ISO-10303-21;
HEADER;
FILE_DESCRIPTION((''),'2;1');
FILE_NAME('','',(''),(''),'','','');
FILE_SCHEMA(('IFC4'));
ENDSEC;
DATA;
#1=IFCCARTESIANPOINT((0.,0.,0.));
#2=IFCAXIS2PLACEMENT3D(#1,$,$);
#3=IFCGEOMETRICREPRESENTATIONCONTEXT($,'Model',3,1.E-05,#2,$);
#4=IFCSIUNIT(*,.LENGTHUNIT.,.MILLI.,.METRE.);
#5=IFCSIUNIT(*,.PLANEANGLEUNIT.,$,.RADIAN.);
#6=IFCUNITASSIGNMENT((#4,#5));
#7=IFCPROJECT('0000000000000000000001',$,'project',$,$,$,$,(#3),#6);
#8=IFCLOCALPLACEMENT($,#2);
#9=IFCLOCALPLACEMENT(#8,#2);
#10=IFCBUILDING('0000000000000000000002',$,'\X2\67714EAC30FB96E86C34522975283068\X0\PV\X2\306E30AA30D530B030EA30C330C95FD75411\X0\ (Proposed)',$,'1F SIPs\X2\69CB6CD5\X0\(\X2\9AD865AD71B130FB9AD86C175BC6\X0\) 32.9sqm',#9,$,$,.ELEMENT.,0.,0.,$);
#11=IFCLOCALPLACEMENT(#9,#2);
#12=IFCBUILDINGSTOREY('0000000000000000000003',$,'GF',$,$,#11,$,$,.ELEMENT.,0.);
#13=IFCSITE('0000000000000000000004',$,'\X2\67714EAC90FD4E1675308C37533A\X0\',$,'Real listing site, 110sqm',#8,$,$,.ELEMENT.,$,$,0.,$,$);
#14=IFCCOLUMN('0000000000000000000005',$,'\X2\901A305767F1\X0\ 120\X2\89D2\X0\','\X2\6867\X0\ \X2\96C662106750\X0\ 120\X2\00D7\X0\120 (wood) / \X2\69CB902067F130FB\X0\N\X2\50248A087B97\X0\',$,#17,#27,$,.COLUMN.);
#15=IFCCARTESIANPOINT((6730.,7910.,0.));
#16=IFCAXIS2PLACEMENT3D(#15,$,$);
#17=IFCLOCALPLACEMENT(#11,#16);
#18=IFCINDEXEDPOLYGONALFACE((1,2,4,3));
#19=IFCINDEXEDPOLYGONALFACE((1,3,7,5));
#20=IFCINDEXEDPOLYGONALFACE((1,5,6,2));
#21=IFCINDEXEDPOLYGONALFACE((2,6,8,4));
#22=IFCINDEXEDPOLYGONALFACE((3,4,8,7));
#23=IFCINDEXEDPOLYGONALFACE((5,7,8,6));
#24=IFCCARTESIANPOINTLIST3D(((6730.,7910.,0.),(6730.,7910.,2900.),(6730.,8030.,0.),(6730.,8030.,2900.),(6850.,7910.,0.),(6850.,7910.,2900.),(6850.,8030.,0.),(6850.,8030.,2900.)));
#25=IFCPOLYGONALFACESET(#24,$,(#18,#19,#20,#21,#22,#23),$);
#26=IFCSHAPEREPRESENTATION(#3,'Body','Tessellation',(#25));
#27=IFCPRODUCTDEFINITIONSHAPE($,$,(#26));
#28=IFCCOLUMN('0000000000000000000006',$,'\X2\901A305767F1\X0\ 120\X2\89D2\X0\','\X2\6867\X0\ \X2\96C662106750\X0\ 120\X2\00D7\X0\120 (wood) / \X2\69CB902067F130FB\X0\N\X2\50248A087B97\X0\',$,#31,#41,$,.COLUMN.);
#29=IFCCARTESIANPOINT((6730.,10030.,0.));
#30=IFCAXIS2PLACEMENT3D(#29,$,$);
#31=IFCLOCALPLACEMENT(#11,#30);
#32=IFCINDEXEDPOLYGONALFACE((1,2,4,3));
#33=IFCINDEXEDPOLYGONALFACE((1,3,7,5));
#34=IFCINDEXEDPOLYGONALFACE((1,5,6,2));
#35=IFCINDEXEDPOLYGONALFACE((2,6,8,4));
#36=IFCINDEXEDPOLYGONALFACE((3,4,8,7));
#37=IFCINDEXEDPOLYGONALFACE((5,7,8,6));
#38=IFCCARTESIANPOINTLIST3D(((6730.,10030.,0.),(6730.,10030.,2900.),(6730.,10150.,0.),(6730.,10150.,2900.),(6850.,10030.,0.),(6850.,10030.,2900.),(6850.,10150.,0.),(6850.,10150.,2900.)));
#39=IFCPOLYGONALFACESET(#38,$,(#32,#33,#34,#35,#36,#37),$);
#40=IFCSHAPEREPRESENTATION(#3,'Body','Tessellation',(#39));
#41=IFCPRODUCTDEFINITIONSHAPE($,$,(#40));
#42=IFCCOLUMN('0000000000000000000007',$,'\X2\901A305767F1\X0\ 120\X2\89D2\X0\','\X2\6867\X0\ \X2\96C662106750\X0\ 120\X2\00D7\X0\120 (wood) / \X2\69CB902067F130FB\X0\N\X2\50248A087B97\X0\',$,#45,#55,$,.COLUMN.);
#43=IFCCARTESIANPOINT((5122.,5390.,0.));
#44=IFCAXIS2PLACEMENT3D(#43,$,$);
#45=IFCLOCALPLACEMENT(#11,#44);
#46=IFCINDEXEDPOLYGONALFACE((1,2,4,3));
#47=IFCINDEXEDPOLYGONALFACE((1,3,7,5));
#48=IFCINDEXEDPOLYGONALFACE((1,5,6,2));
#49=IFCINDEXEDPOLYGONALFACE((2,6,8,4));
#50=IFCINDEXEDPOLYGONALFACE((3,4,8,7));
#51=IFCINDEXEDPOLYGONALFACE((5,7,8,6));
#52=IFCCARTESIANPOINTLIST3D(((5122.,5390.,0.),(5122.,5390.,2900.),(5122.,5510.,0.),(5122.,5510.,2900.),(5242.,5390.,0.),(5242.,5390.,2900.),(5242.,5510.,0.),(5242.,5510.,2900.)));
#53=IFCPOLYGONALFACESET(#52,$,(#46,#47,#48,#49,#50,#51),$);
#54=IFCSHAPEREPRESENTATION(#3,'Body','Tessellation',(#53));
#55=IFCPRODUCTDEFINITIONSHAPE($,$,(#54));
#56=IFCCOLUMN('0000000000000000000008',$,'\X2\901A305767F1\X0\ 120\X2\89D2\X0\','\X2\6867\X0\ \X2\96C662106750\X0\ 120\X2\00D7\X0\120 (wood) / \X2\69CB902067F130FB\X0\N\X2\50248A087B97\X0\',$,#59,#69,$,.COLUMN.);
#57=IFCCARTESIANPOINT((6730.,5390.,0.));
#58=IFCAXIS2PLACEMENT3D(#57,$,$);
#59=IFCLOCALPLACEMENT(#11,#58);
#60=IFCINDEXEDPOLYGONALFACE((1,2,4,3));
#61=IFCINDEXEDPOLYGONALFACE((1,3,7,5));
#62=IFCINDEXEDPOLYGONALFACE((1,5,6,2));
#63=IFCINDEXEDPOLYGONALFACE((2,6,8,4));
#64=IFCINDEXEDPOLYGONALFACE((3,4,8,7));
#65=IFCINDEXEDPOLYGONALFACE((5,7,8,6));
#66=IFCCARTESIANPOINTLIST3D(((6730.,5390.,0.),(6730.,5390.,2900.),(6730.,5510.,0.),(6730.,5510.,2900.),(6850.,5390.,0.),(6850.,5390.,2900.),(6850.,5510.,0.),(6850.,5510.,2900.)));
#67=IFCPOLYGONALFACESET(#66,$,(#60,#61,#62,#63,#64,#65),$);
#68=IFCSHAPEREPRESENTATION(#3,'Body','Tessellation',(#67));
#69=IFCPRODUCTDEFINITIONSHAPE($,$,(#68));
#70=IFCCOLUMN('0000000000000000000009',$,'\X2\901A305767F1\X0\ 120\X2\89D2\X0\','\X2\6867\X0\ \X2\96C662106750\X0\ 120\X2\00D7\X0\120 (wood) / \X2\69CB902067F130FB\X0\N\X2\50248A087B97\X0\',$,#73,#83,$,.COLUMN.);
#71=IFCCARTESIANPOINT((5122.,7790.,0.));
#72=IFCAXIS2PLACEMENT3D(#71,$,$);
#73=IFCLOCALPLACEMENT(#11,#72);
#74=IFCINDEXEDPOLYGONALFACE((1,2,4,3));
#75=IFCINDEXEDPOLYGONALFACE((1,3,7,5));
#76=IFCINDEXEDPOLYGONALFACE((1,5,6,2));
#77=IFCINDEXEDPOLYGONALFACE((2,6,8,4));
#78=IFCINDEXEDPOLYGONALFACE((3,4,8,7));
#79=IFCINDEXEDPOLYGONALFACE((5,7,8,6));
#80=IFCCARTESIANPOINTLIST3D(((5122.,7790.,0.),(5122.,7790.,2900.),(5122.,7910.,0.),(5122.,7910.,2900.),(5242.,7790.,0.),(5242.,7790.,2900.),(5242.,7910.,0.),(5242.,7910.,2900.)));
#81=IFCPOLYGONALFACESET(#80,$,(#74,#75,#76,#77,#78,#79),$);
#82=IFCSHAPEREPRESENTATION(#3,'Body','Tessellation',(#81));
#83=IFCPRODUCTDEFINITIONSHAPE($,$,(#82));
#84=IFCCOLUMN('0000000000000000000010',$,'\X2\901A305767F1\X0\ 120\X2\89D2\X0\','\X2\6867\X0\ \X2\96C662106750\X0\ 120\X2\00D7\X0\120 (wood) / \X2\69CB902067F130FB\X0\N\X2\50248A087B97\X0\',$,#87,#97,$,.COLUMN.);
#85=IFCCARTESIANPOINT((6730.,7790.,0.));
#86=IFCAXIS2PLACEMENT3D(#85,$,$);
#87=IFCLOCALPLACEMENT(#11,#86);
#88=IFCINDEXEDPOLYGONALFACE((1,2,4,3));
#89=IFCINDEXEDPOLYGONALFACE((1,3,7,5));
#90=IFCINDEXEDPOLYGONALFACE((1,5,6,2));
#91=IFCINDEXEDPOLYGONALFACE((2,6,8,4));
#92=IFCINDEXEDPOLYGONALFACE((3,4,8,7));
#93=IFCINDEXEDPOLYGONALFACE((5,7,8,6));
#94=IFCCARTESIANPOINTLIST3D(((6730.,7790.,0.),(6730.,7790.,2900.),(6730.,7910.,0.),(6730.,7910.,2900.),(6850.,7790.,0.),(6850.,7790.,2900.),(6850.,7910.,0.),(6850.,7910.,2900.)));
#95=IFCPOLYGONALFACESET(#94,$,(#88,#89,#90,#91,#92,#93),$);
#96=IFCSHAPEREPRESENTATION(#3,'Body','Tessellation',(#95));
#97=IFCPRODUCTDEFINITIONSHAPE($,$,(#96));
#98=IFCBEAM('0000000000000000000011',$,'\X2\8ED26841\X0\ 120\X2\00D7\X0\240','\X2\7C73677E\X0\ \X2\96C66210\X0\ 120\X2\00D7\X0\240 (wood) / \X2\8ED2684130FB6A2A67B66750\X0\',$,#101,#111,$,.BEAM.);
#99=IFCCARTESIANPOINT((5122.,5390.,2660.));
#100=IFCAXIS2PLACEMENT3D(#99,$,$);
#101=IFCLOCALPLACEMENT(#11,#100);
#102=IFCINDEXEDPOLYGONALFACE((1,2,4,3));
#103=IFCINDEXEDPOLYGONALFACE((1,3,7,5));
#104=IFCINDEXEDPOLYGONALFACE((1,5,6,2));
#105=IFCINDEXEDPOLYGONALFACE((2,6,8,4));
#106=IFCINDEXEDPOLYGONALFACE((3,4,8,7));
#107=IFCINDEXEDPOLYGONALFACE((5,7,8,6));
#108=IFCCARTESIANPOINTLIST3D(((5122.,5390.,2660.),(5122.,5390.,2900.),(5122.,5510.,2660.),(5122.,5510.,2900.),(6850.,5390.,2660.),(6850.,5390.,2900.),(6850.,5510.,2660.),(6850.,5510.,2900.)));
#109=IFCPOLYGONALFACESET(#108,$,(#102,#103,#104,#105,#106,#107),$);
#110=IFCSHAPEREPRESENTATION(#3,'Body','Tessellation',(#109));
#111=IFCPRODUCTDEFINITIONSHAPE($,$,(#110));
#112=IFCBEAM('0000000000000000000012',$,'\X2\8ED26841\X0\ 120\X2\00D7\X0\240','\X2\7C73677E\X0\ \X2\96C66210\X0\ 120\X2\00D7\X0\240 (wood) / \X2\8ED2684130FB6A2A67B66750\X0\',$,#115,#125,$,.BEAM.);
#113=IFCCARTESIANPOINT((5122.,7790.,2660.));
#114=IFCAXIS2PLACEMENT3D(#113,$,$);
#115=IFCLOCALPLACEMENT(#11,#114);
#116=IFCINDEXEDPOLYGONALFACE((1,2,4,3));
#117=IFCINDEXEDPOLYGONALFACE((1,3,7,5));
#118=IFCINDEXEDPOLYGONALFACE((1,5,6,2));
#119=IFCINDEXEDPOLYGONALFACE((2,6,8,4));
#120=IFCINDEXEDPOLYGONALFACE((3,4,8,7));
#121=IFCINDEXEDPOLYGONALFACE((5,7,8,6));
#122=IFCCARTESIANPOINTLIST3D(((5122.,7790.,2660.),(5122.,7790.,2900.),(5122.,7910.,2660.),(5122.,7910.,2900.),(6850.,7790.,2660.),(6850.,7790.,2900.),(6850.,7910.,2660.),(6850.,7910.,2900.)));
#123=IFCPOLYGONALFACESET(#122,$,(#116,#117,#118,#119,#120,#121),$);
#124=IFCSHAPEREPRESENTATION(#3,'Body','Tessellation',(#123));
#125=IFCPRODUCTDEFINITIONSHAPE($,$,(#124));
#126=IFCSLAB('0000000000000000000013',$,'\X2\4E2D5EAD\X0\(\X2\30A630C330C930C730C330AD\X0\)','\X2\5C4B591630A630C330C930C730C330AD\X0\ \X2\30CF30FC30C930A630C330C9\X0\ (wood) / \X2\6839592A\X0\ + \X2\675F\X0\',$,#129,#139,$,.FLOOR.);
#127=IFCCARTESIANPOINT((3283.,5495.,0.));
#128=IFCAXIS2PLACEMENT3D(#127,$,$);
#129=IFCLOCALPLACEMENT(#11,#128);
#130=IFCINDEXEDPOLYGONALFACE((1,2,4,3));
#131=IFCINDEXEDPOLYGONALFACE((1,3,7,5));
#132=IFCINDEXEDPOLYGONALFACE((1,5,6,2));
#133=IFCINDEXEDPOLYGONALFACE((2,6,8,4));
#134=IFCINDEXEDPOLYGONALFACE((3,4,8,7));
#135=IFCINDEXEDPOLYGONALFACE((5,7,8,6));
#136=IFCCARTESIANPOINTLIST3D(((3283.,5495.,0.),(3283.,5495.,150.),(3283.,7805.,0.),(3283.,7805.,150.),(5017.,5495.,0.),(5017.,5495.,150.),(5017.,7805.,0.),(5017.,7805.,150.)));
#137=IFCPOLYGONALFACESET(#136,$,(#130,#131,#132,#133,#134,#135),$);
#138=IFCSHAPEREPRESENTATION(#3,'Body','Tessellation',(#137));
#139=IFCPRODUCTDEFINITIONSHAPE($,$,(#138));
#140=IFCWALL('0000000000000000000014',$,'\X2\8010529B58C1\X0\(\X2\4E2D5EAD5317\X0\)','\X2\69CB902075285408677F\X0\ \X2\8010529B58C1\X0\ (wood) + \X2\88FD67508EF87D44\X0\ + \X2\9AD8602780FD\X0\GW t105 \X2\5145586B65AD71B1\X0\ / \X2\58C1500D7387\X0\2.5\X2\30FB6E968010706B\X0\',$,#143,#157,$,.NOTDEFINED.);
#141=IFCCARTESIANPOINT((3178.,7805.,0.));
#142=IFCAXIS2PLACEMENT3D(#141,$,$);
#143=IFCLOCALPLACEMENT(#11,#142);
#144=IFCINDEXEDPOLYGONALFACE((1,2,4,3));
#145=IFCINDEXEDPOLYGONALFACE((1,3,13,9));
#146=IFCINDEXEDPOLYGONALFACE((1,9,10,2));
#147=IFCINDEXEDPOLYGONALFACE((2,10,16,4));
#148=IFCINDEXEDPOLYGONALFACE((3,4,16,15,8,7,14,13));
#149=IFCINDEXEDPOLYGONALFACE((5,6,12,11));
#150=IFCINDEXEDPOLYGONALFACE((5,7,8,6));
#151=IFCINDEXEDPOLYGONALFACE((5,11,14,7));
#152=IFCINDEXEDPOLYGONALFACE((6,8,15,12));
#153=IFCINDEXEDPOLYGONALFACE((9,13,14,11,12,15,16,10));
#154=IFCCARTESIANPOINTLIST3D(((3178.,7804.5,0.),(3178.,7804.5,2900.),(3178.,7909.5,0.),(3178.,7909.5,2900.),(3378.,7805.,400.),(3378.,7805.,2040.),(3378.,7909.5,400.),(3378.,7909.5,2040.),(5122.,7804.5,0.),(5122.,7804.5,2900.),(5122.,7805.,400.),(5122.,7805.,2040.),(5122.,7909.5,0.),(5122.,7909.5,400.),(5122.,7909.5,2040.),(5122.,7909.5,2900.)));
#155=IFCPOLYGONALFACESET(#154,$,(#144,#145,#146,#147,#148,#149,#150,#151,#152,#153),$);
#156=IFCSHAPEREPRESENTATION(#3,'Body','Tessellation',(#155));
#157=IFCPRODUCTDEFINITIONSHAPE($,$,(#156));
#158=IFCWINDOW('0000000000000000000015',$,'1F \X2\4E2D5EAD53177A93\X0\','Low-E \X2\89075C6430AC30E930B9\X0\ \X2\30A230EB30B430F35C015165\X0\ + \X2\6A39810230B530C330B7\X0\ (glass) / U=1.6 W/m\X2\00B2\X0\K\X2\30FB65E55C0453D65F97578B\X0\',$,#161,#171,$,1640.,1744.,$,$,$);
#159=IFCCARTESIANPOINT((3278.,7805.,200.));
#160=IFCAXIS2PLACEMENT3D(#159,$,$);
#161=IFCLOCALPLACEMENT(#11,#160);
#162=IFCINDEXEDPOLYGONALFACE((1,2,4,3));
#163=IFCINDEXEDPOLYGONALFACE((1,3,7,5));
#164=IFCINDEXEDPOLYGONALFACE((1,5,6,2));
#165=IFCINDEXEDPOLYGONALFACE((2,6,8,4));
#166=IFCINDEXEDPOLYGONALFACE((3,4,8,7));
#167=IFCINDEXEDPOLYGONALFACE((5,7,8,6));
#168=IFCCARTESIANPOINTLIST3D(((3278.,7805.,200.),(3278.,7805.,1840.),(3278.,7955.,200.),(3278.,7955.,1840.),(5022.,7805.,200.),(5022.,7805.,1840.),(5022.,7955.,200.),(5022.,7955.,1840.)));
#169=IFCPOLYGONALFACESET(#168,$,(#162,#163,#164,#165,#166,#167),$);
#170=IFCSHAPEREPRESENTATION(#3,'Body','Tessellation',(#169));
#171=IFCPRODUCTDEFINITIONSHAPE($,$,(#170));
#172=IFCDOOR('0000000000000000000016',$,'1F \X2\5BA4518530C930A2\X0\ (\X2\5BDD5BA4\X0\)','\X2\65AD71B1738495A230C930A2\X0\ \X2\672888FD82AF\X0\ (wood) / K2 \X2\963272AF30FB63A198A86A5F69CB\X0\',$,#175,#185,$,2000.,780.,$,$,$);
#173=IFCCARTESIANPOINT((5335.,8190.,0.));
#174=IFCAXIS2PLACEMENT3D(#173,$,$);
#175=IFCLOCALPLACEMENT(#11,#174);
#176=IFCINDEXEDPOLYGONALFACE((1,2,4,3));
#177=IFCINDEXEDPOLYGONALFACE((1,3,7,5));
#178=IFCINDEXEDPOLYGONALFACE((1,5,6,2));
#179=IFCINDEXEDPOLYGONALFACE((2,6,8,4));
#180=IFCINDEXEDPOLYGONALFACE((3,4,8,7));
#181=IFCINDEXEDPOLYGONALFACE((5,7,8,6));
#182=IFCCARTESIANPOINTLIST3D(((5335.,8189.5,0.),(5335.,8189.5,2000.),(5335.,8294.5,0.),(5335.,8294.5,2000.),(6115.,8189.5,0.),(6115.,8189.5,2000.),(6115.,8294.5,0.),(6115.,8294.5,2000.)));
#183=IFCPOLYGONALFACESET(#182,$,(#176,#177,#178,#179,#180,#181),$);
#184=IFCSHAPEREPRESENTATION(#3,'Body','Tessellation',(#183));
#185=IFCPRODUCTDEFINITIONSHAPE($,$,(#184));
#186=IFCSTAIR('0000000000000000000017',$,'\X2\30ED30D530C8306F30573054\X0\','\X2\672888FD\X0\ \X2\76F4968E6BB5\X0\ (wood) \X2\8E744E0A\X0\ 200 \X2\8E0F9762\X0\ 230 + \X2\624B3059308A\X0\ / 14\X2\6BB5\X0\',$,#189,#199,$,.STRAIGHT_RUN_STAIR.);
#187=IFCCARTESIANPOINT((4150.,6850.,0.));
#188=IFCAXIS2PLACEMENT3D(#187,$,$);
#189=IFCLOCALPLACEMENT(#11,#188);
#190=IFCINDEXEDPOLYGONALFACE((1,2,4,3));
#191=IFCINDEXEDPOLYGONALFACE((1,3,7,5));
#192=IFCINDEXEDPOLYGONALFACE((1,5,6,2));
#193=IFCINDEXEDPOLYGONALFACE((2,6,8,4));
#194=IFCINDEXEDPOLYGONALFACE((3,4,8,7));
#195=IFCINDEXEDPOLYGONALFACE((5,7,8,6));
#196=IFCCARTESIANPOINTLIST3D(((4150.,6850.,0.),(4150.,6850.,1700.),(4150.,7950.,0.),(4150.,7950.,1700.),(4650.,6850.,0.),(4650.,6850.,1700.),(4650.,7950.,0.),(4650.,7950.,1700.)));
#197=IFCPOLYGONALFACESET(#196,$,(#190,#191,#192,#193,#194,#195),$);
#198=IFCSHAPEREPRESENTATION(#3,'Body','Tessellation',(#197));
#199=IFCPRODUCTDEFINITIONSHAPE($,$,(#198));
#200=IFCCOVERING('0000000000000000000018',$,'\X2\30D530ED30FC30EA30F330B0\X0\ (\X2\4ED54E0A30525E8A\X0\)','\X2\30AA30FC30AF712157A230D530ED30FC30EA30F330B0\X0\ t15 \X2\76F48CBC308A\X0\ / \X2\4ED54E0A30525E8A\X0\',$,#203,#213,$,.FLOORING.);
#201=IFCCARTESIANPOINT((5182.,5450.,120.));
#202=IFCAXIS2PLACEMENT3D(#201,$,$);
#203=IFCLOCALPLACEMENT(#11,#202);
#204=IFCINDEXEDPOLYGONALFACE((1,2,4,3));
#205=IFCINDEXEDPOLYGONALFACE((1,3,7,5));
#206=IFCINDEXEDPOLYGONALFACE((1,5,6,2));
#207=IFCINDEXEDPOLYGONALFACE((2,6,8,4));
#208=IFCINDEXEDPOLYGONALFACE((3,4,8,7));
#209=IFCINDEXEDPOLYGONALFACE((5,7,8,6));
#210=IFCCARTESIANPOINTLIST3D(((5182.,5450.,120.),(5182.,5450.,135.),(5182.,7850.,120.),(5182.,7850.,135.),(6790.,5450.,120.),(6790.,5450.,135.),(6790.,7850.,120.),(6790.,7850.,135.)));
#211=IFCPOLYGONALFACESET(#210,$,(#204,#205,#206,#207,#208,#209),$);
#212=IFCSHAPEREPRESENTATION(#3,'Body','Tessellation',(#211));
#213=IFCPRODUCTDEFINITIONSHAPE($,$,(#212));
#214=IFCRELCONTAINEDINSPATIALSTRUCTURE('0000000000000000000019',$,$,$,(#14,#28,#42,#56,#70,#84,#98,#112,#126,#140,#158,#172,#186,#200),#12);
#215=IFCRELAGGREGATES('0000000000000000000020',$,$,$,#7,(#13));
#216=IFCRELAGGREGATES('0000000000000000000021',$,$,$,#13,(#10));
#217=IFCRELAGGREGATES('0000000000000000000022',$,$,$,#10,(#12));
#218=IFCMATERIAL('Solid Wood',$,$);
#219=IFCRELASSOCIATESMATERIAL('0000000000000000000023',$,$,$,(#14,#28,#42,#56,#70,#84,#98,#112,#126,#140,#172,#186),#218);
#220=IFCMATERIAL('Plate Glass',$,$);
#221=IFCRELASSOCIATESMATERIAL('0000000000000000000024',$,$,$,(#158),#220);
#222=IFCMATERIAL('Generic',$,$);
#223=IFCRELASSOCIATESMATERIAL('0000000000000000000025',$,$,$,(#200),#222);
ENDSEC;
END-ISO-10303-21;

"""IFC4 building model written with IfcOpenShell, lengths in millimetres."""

from ifc_helpers import new_model, si_unit, frame, frame_2d, origin, place, context, project, spatial, rectangle, extrude, material, element, fill, save


model = new_model("IFC4")

# Units and contexts
model_context = context("Model", 3, precision=1e-05, world=origin())
ifc_project = project(units=[si_unit("LENGTHUNIT", "METRE", prefix="MILLI"), si_unit("PLANEANGLEUNIT", "RADIAN")], contexts=[model_context])

# Site, building, storey
site_placement = place(None, origin())
site = spatial("IfcSite", under=ifc_project, at=site_placement, Name="東京都世田谷区", ObjectType="Real listing site, 110sqm", CompositionType="ELEMENT", RefElevation=0.0)
building_placement = place(site_placement, origin())
building = spatial("IfcBuilding", under=site, at=building_placement, Name="東京・雨水利用とPVのオフグリッド志向 (Proposed)", ObjectType="1F SIPs構法(高断熱・高気密) 32.9sqm", CompositionType="ELEMENT", ElevationOfRefHeight=0.0, ElevationOfTerrain=0.0)
storey_placement = place(building_placement, origin())
storey = spatial("IfcBuildingStorey", under=building, at=storey_placement, Name="GF", CompositionType="ELEMENT", Elevation=0.0)

# Columns
ifc_material_1 = material(Name="Solid Wood")
column_1_placement = place(storey_placement, frame((6730.0, 7910.0, 0.0)))
element("IfcColumn", 1, at=column_1_placement, inside=storey, material=ifc_material_1, Name="通し柱 120角", Description="桧 集成材 120×120 (wood) / 構造柱・N値計算", PredefinedType="COLUMN", context=model_context, shape_type="SweptSolid", body=[
    extrude(rectangle(XDim=120.0, YDim=120.0, at=frame_2d((60.0, 60.0))), frame((6730.0, 7910.0, 0.0)), (0.0, 0.0, 1.0), 2900.0),
])
column_2_placement = place(storey_placement, frame((6730.0, 10030.0, 0.0)))
element("IfcColumn", 2, at=column_2_placement, inside=storey, material=ifc_material_1, Name="通し柱 120角", Description="桧 集成材 120×120 (wood) / 構造柱・N値計算", PredefinedType="COLUMN", context=model_context, shape_type="SweptSolid", body=[
    extrude(rectangle(XDim=120.0, YDim=120.0, at=frame_2d((60.0, 60.0))), frame((6730.0, 10030.0, 0.0)), (0.0, 0.0, 1.0), 2900.0),
])
column_3_placement = place(storey_placement, frame((5122.0, 5390.0, 0.0)))
element("IfcColumn", 3, at=column_3_placement, inside=storey, material=ifc_material_1, Name="通し柱 120角", Description="桧 集成材 120×120 (wood) / 構造柱・N値計算", PredefinedType="COLUMN", context=model_context, shape_type="SweptSolid", body=[
    extrude(rectangle(XDim=120.0, YDim=120.0, at=frame_2d((60.0, 60.0))), frame((5122.0, 5390.0, 0.0)), (0.0, 0.0, 1.0), 2900.0),
])
column_4_placement = place(storey_placement, frame((6730.0, 5390.0, 0.0)))
element("IfcColumn", 4, at=column_4_placement, inside=storey, material=ifc_material_1, Name="通し柱 120角", Description="桧 集成材 120×120 (wood) / 構造柱・N値計算", PredefinedType="COLUMN", context=model_context, shape_type="SweptSolid", body=[
    extrude(rectangle(XDim=120.0, YDim=120.0, at=frame_2d((60.0, 60.0))), frame((6730.0, 5390.0, 0.0)), (0.0, 0.0, 1.0), 2900.0),
])
column_5_placement = place(storey_placement, frame((5122.0, 7790.0, 0.0)))
element("IfcColumn", 5, at=column_5_placement, inside=storey, material=ifc_material_1, Name="通し柱 120角", Description="桧 集成材 120×120 (wood) / 構造柱・N値計算", PredefinedType="COLUMN", context=model_context, shape_type="SweptSolid", body=[
    extrude(rectangle(XDim=120.0, YDim=120.0, at=frame_2d((60.0, 60.0))), frame((5122.0, 7790.0, 0.0)), (0.0, 0.0, 1.0), 2900.0),
])
column_6_placement = place(storey_placement, frame((6730.0, 7790.0, 0.0)))
element("IfcColumn", 6, at=column_6_placement, inside=storey, material=ifc_material_1, Name="通し柱 120角", Description="桧 集成材 120×120 (wood) / 構造柱・N値計算", PredefinedType="COLUMN", context=model_context, shape_type="SweptSolid", body=[
    extrude(rectangle(XDim=120.0, YDim=120.0, at=frame_2d((60.0, 60.0))), frame((6730.0, 7790.0, 0.0)), (0.0, 0.0, 1.0), 2900.0),
])

# Beams
beam_1_placement = place(storey_placement, frame((5122.0, 5390.0, 2660.0)))
element("IfcBeam", 7, at=beam_1_placement, inside=storey, material=ifc_material_1, Name="軒桁 120×240", Description="米松 集成 120×240 (wood) / 軒桁・横架材", PredefinedType="BEAM", context=model_context, shape_type="SweptSolid", body=[
    extrude(rectangle(XDim=1728.0, YDim=120.0, at=frame_2d((864.0, 60.0))), frame((5122.0, 5390.0, 2660.0)), (0.0, 0.0, 1.0), 240.0),
])
beam_2_placement = place(storey_placement, frame((5122.0, 7790.0, 2660.0)))
element("IfcBeam", 8, at=beam_2_placement, inside=storey, material=ifc_material_1, Name="軒桁 120×240", Description="米松 集成 120×240 (wood) / 軒桁・横架材", PredefinedType="BEAM", context=model_context, shape_type="SweptSolid", body=[
    extrude(rectangle(XDim=1728.0, YDim=120.0, at=frame_2d((864.0, 60.0))), frame((5122.0, 7790.0, 2660.0)), (0.0, 0.0, 1.0), 240.0),
])

# Slab
slab_placement = place(storey_placement, frame((3283.0, 5495.0, 0.0)))
element("IfcSlab", 9, at=slab_placement, inside=storey, material=ifc_material_1, Name="中庭(ウッドデッキ)", Description="屋外ウッドデッキ ハードウッド (wood) / 根太 + 束", PredefinedType="FLOOR", context=model_context, shape_type="SweptSolid", body=[
    extrude(rectangle(XDim=1734.0, YDim=2310.0, at=frame_2d((867.0, 1155.0))), frame((3283.0, 5495.0, 0.0)), (0.0, 0.0, 1.0), 150.0),
])

# Wall, opening, window
wall_1_placement = place(storey_placement, frame((3178.0, 7805.0, 0.0)))
wall_1 = element("IfcWall", 10, at=wall_1_placement, inside=storey, material=ifc_material_1, Name="耐力壁(中庭北)", Description="構造用合板 耐力壁 (wood) + 製材軸組 + 高性能GW t105 充填断熱 / 壁倍率2.5・準耐火", PredefinedType="NOTDEFINED", context=model_context, shape_type="SweptSolid", body=[
    extrude(rectangle(XDim=1944.0, YDim=105.0, at=frame_2d((972.0, 52.0))), frame((3178.0, 7805.0, 0.0)), (0.0, 0.0, 1.0), 2900.0),
])
opening_placement = place(storey_placement, frame((3278.0, 7805.0, 200.0)))
opening = element("IfcOpeningElement", 11, at=opening_placement, cuts=wall_1, PredefinedType="NOTDEFINED", context=model_context, shape_type="SweptSolid", body=[
    extrude(rectangle(XDim=1744.0, YDim=150.0, at=frame_2d((872.0, 75.0))), frame((3278.0, 7805.0, 200.0)), (0.0, 0.0, 1.0), 1640.0),
])
ifc_material_2 = material(Name="Plate Glass")
window_placement = place(storey_placement, frame((3278.0, 7805.0, 200.0)))
window = element("IfcWindow", 12, at=window_placement, inside=storey, material=ifc_material_2, Name="1F 中庭北窓", Description="Low-E 複層ガラス アルゴン封入 + 樹脂サッシ (glass) / U=1.6 W/m²K・日射取得型", OverallHeight=1640.0, OverallWidth=1744.0, context=model_context, shape_type="SweptSolid", body=[
    extrude(rectangle(XDim=1744.0, YDim=150.0, at=frame_2d((872.0, 75.0))), frame((3278.0, 7805.0, 200.0)), (0.0, 0.0, 1.0), 1640.0),
])
fill(opening, window)

# Door
door_placement = place(storey_placement, frame((5335.0, 8190.0, 0.0)))
element("IfcDoor", 13, at=door_placement, inside=storey, material=ifc_material_1, Name="1F 室内ドア (寝室)", Description="断熱玄関ドア 木製芯 (wood) / K2 防犯・採風機構", OverallHeight=2000.0, OverallWidth=780.0, context=model_context, shape_type="SweptSolid", body=[
    extrude(rectangle(XDim=780.0, YDim=105.0, at=frame_2d((390.0, 52.0))), frame((5335.0, 8190.0, 0.0)), (0.0, 0.0, 1.0), 2000.0),
])

# Stair
stair_placement = place(storey_placement, frame((4150.0, 6850.0, 0.0)))
element("IfcStair", 14, at=stair_placement, inside=storey, material=ifc_material_1, Name="ロフトはしご", Description="木製 直階段 (wood) 蹴上 200 踏面 230 + 手すり / 14段", PredefinedType="STRAIGHT_RUN_STAIR", context=model_context, shape_type="SweptSolid", body=[
    extrude(rectangle(XDim=500.0, YDim=1100.0, at=frame_2d((250.0, 550.0))), frame((4150.0, 6850.0, 0.0)), (0.0, 0.0, 1.0), 1700.0),
])

# Covering
ifc_material_3 = material(Name="Generic")
covering_placement = place(storey_placement, frame((5182.0, 5450.0, 120.0)))
element("IfcCovering", 15, at=covering_placement, inside=storey, material=ifc_material_3, Name="フローリング (仕上げ床)", Description="オーク無垢フローリング t15 直貼り / 仕上げ床", PredefinedType="FLOORING", context=model_context, shape_type="SweptSolid", body=[
    extrude(rectangle(XDim=1608.0, YDim=2400.0, at=frame_2d((804.0, 1200.0))), frame((5182.0, 5450.0, 120.0)), (0.0, 0.0, 1.0), 15.0),
])

save(model, "model.ifc")
